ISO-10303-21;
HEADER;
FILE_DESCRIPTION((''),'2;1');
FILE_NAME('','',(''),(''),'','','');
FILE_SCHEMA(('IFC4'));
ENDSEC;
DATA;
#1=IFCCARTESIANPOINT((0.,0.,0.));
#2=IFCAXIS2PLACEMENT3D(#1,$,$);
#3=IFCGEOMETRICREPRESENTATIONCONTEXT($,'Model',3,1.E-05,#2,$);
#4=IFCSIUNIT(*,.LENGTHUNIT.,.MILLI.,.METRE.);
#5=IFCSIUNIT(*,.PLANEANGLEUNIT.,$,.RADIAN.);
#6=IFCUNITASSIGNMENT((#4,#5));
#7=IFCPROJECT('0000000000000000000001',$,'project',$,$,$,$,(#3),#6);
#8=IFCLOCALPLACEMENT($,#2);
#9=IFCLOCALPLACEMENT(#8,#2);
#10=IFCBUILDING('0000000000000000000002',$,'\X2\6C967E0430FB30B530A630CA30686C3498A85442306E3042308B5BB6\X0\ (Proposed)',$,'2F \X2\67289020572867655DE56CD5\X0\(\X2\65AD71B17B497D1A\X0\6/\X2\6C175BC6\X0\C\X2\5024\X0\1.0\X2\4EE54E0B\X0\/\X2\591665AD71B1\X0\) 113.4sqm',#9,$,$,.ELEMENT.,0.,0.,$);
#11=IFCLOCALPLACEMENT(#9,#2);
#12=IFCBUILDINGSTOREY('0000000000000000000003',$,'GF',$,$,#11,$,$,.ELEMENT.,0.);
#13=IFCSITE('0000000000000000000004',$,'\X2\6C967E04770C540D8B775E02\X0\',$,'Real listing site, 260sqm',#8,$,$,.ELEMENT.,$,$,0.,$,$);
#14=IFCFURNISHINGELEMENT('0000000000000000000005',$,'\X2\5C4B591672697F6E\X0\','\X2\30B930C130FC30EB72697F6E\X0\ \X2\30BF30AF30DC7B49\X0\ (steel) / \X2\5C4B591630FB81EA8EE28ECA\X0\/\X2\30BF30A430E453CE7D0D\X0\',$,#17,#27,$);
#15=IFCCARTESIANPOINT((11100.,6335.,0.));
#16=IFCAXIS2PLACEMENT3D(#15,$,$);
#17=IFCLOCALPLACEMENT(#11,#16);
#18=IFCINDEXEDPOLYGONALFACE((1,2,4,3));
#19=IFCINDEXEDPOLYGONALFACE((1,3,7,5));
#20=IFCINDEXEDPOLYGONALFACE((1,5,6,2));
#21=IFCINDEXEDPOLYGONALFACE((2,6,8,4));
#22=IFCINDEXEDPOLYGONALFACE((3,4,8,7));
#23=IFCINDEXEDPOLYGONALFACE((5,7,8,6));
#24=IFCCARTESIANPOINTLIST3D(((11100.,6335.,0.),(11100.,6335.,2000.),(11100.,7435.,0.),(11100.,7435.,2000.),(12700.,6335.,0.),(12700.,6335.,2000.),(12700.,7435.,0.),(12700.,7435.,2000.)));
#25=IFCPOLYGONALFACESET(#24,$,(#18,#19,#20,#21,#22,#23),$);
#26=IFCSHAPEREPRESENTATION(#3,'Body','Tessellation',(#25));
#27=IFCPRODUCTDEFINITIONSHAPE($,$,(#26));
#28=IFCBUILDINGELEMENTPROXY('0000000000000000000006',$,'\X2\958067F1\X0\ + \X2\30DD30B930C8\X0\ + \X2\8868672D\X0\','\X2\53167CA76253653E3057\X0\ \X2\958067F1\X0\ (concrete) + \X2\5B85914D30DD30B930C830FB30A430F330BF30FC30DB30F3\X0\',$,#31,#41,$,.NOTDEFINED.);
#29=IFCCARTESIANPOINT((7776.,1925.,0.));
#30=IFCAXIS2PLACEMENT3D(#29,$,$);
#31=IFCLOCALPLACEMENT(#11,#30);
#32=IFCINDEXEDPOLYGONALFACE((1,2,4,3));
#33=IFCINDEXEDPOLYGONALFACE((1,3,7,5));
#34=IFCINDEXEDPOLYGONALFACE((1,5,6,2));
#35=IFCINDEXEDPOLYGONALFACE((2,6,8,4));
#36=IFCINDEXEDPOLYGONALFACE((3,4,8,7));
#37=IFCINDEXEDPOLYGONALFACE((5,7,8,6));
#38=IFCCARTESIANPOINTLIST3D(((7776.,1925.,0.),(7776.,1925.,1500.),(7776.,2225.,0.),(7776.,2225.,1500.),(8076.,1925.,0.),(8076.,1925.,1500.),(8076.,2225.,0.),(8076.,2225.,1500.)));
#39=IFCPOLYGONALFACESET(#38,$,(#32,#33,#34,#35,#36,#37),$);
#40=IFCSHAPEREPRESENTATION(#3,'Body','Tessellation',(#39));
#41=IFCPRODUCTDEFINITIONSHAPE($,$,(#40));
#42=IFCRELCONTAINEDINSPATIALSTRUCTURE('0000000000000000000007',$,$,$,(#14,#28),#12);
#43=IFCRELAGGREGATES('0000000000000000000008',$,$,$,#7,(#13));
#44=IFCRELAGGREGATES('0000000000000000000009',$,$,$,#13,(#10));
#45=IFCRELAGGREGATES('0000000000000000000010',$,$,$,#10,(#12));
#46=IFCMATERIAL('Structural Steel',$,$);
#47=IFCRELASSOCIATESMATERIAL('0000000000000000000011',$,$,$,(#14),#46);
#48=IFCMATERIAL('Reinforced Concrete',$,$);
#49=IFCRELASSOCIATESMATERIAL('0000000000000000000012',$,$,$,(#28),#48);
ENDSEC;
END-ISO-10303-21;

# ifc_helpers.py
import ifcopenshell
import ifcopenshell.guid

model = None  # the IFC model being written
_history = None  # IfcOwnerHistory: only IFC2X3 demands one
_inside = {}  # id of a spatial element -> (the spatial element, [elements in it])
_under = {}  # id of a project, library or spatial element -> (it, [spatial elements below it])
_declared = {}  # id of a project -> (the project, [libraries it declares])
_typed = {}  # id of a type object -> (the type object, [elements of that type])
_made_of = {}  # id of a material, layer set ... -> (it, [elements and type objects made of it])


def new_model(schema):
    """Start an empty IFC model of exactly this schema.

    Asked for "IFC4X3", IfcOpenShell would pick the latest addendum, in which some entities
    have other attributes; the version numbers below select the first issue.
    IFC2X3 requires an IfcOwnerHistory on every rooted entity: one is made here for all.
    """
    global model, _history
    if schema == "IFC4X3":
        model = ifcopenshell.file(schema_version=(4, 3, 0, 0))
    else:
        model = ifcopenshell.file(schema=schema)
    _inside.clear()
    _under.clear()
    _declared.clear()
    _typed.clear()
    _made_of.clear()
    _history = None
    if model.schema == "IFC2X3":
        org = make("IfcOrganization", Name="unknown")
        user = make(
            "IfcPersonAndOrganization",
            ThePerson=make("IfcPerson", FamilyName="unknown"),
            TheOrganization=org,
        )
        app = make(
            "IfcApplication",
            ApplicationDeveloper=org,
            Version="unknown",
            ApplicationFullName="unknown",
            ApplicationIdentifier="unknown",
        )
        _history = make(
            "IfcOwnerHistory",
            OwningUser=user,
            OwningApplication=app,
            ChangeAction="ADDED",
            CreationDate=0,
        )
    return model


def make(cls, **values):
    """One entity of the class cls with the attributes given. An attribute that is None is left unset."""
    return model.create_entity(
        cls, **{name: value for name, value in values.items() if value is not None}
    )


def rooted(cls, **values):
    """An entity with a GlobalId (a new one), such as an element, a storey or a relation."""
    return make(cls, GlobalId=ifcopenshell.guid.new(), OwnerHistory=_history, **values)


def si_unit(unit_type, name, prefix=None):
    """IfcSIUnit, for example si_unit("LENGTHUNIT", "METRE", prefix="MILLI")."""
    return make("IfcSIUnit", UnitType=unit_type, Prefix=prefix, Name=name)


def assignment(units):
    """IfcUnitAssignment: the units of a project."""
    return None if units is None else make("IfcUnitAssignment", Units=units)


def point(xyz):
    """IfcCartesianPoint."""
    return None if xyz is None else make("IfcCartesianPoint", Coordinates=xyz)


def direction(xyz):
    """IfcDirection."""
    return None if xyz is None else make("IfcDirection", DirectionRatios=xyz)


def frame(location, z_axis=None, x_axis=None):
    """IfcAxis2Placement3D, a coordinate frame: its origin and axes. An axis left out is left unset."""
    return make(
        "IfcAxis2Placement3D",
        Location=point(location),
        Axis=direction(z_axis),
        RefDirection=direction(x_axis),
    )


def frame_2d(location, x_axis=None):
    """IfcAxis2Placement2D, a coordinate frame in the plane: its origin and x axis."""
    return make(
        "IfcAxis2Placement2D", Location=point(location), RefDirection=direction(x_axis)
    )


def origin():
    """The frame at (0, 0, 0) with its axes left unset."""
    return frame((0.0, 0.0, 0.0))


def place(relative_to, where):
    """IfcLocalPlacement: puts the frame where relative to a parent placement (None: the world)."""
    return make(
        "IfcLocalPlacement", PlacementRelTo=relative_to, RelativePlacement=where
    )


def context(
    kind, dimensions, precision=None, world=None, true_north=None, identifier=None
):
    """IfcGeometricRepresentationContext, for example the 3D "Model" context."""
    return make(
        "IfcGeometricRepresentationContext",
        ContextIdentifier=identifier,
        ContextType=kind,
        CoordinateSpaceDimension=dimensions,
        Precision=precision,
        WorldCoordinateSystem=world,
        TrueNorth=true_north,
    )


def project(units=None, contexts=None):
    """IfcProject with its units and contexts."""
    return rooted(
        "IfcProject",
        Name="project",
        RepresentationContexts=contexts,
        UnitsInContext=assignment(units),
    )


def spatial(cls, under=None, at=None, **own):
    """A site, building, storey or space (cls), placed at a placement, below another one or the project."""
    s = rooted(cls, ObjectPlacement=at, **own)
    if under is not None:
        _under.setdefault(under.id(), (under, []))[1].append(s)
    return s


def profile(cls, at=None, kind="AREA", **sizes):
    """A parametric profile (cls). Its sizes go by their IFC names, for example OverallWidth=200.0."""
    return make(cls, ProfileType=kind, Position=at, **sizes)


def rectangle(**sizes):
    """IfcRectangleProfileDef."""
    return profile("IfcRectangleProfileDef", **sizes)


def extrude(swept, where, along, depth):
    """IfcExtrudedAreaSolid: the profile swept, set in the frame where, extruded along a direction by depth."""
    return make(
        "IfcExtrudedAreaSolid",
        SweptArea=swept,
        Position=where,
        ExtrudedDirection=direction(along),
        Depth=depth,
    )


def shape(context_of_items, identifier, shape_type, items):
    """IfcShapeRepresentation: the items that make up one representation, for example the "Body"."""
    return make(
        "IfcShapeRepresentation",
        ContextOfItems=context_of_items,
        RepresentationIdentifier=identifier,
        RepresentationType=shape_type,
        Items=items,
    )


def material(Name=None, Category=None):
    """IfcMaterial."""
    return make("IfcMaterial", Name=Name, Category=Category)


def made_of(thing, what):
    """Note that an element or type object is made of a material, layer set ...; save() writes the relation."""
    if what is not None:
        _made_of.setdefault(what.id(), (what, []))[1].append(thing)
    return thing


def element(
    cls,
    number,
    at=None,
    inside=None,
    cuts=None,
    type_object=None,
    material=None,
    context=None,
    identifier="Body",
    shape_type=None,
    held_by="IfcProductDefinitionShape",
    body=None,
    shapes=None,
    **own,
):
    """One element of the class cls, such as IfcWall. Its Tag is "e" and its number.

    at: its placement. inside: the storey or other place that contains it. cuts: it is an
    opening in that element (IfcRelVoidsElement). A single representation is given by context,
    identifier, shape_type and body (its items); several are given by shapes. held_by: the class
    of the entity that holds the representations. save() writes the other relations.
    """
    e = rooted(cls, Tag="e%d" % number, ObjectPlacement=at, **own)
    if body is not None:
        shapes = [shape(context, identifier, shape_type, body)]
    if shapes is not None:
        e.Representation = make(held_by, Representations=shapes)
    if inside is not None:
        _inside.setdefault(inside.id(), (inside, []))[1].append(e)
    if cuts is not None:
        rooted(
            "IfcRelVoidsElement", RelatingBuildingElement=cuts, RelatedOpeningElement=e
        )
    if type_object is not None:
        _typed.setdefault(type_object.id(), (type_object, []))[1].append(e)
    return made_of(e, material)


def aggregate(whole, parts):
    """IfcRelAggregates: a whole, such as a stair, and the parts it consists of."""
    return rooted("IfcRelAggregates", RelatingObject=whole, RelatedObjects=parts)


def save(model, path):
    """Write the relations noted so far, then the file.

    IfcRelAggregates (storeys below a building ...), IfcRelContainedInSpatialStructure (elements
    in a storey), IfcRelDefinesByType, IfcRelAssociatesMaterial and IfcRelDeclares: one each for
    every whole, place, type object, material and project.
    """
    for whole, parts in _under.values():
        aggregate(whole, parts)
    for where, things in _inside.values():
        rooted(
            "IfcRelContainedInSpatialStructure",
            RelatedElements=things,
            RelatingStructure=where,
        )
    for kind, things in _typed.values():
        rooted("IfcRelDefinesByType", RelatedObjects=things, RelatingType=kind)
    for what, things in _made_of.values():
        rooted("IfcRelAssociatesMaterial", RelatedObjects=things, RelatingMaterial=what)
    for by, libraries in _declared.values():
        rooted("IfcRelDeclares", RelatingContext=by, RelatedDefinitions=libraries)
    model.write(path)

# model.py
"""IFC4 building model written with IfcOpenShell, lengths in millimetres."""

from ifc_helpers import new_model, si_unit, frame, frame_2d, origin, place, context, project, spatial, rectangle, extrude, material, element, save


model = new_model("IFC4")

# Units and contexts
model_context = context("Model", 3, precision=1e-05, world=origin())
ifc_project = project(units=[si_unit("LENGTHUNIT", "METRE", prefix="MILLI"), si_unit("PLANEANGLEUNIT", "RADIAN")], contexts=[model_context])

# Site, building, storey
site_placement = place(None, origin())
site = spatial("IfcSite", under=ifc_project, at=site_placement, Name="沖縄県名護市", ObjectType="Real listing site, 260sqm", CompositionType="ELEMENT", RefElevation=0.0)
building_placement = place(site_placement, origin())
building = spatial("IfcBuilding", under=site, at=building_placement, Name="沖縄・サウナと水風呂のある家 (Proposed)", ObjectType="2F 木造在来工法(断熱等級6/気密C値1.0以下/外断熱) 113.4sqm", CompositionType="ELEMENT", ElevationOfRefHeight=0.0, ElevationOfTerrain=0.0)
storey_placement = place(building_placement, origin())
storey = spatial("IfcBuildingStorey", under=building, at=storey_placement, Name="GF", CompositionType="ELEMENT", Elevation=0.0)

# Shared definitions
ifc_material_1 = material(Name="Reinforced Concrete")

# Shared definitions
ifc_material_2 = material(Name="Structural Steel")

# Furnishing element
furnishing_1_placement = place(storey_placement, frame((11100.0, 6335.0, 0.0)))
element("IfcFurnishingElement", 1, at=furnishing_1_placement, inside=storey, material=ifc_material_2, Name="屋外物置", Description="スチール物置 タクボ等 (steel) / 屋外・自転車/タイヤ収納", context=model_context, shape_type="SweptSolid", body=[
    extrude(rectangle(XDim=1600.0, YDim=1100.0, at=frame_2d((800.0, 550.0))), frame((11100.0, 6335.0, 0.0)), (0.0, 0.0, 1.0), 2000.0),
])

# Building element proxy
proxy_placement = place(storey_placement, frame((7776.0, 1925.0, 0.0)))
element("IfcBuildingElementProxy", 2, at=proxy_placement, inside=storey, material=ifc_material_1, Name="門柱 + ポスト + 表札", Description="化粧打放し 門柱 (concrete) + 宅配ポスト・インターホン", PredefinedType="NOTDEFINED", context=model_context, shape_type="SweptSolid", body=[
    extrude(rectangle(XDim=300.0, YDim=300.0, at=frame_2d((150.0, 150.0))), frame((7776.0, 1925.0, 0.0)), (0.0, 0.0, 1.0), 1500.0),
])

save(model, "model.ifc")
